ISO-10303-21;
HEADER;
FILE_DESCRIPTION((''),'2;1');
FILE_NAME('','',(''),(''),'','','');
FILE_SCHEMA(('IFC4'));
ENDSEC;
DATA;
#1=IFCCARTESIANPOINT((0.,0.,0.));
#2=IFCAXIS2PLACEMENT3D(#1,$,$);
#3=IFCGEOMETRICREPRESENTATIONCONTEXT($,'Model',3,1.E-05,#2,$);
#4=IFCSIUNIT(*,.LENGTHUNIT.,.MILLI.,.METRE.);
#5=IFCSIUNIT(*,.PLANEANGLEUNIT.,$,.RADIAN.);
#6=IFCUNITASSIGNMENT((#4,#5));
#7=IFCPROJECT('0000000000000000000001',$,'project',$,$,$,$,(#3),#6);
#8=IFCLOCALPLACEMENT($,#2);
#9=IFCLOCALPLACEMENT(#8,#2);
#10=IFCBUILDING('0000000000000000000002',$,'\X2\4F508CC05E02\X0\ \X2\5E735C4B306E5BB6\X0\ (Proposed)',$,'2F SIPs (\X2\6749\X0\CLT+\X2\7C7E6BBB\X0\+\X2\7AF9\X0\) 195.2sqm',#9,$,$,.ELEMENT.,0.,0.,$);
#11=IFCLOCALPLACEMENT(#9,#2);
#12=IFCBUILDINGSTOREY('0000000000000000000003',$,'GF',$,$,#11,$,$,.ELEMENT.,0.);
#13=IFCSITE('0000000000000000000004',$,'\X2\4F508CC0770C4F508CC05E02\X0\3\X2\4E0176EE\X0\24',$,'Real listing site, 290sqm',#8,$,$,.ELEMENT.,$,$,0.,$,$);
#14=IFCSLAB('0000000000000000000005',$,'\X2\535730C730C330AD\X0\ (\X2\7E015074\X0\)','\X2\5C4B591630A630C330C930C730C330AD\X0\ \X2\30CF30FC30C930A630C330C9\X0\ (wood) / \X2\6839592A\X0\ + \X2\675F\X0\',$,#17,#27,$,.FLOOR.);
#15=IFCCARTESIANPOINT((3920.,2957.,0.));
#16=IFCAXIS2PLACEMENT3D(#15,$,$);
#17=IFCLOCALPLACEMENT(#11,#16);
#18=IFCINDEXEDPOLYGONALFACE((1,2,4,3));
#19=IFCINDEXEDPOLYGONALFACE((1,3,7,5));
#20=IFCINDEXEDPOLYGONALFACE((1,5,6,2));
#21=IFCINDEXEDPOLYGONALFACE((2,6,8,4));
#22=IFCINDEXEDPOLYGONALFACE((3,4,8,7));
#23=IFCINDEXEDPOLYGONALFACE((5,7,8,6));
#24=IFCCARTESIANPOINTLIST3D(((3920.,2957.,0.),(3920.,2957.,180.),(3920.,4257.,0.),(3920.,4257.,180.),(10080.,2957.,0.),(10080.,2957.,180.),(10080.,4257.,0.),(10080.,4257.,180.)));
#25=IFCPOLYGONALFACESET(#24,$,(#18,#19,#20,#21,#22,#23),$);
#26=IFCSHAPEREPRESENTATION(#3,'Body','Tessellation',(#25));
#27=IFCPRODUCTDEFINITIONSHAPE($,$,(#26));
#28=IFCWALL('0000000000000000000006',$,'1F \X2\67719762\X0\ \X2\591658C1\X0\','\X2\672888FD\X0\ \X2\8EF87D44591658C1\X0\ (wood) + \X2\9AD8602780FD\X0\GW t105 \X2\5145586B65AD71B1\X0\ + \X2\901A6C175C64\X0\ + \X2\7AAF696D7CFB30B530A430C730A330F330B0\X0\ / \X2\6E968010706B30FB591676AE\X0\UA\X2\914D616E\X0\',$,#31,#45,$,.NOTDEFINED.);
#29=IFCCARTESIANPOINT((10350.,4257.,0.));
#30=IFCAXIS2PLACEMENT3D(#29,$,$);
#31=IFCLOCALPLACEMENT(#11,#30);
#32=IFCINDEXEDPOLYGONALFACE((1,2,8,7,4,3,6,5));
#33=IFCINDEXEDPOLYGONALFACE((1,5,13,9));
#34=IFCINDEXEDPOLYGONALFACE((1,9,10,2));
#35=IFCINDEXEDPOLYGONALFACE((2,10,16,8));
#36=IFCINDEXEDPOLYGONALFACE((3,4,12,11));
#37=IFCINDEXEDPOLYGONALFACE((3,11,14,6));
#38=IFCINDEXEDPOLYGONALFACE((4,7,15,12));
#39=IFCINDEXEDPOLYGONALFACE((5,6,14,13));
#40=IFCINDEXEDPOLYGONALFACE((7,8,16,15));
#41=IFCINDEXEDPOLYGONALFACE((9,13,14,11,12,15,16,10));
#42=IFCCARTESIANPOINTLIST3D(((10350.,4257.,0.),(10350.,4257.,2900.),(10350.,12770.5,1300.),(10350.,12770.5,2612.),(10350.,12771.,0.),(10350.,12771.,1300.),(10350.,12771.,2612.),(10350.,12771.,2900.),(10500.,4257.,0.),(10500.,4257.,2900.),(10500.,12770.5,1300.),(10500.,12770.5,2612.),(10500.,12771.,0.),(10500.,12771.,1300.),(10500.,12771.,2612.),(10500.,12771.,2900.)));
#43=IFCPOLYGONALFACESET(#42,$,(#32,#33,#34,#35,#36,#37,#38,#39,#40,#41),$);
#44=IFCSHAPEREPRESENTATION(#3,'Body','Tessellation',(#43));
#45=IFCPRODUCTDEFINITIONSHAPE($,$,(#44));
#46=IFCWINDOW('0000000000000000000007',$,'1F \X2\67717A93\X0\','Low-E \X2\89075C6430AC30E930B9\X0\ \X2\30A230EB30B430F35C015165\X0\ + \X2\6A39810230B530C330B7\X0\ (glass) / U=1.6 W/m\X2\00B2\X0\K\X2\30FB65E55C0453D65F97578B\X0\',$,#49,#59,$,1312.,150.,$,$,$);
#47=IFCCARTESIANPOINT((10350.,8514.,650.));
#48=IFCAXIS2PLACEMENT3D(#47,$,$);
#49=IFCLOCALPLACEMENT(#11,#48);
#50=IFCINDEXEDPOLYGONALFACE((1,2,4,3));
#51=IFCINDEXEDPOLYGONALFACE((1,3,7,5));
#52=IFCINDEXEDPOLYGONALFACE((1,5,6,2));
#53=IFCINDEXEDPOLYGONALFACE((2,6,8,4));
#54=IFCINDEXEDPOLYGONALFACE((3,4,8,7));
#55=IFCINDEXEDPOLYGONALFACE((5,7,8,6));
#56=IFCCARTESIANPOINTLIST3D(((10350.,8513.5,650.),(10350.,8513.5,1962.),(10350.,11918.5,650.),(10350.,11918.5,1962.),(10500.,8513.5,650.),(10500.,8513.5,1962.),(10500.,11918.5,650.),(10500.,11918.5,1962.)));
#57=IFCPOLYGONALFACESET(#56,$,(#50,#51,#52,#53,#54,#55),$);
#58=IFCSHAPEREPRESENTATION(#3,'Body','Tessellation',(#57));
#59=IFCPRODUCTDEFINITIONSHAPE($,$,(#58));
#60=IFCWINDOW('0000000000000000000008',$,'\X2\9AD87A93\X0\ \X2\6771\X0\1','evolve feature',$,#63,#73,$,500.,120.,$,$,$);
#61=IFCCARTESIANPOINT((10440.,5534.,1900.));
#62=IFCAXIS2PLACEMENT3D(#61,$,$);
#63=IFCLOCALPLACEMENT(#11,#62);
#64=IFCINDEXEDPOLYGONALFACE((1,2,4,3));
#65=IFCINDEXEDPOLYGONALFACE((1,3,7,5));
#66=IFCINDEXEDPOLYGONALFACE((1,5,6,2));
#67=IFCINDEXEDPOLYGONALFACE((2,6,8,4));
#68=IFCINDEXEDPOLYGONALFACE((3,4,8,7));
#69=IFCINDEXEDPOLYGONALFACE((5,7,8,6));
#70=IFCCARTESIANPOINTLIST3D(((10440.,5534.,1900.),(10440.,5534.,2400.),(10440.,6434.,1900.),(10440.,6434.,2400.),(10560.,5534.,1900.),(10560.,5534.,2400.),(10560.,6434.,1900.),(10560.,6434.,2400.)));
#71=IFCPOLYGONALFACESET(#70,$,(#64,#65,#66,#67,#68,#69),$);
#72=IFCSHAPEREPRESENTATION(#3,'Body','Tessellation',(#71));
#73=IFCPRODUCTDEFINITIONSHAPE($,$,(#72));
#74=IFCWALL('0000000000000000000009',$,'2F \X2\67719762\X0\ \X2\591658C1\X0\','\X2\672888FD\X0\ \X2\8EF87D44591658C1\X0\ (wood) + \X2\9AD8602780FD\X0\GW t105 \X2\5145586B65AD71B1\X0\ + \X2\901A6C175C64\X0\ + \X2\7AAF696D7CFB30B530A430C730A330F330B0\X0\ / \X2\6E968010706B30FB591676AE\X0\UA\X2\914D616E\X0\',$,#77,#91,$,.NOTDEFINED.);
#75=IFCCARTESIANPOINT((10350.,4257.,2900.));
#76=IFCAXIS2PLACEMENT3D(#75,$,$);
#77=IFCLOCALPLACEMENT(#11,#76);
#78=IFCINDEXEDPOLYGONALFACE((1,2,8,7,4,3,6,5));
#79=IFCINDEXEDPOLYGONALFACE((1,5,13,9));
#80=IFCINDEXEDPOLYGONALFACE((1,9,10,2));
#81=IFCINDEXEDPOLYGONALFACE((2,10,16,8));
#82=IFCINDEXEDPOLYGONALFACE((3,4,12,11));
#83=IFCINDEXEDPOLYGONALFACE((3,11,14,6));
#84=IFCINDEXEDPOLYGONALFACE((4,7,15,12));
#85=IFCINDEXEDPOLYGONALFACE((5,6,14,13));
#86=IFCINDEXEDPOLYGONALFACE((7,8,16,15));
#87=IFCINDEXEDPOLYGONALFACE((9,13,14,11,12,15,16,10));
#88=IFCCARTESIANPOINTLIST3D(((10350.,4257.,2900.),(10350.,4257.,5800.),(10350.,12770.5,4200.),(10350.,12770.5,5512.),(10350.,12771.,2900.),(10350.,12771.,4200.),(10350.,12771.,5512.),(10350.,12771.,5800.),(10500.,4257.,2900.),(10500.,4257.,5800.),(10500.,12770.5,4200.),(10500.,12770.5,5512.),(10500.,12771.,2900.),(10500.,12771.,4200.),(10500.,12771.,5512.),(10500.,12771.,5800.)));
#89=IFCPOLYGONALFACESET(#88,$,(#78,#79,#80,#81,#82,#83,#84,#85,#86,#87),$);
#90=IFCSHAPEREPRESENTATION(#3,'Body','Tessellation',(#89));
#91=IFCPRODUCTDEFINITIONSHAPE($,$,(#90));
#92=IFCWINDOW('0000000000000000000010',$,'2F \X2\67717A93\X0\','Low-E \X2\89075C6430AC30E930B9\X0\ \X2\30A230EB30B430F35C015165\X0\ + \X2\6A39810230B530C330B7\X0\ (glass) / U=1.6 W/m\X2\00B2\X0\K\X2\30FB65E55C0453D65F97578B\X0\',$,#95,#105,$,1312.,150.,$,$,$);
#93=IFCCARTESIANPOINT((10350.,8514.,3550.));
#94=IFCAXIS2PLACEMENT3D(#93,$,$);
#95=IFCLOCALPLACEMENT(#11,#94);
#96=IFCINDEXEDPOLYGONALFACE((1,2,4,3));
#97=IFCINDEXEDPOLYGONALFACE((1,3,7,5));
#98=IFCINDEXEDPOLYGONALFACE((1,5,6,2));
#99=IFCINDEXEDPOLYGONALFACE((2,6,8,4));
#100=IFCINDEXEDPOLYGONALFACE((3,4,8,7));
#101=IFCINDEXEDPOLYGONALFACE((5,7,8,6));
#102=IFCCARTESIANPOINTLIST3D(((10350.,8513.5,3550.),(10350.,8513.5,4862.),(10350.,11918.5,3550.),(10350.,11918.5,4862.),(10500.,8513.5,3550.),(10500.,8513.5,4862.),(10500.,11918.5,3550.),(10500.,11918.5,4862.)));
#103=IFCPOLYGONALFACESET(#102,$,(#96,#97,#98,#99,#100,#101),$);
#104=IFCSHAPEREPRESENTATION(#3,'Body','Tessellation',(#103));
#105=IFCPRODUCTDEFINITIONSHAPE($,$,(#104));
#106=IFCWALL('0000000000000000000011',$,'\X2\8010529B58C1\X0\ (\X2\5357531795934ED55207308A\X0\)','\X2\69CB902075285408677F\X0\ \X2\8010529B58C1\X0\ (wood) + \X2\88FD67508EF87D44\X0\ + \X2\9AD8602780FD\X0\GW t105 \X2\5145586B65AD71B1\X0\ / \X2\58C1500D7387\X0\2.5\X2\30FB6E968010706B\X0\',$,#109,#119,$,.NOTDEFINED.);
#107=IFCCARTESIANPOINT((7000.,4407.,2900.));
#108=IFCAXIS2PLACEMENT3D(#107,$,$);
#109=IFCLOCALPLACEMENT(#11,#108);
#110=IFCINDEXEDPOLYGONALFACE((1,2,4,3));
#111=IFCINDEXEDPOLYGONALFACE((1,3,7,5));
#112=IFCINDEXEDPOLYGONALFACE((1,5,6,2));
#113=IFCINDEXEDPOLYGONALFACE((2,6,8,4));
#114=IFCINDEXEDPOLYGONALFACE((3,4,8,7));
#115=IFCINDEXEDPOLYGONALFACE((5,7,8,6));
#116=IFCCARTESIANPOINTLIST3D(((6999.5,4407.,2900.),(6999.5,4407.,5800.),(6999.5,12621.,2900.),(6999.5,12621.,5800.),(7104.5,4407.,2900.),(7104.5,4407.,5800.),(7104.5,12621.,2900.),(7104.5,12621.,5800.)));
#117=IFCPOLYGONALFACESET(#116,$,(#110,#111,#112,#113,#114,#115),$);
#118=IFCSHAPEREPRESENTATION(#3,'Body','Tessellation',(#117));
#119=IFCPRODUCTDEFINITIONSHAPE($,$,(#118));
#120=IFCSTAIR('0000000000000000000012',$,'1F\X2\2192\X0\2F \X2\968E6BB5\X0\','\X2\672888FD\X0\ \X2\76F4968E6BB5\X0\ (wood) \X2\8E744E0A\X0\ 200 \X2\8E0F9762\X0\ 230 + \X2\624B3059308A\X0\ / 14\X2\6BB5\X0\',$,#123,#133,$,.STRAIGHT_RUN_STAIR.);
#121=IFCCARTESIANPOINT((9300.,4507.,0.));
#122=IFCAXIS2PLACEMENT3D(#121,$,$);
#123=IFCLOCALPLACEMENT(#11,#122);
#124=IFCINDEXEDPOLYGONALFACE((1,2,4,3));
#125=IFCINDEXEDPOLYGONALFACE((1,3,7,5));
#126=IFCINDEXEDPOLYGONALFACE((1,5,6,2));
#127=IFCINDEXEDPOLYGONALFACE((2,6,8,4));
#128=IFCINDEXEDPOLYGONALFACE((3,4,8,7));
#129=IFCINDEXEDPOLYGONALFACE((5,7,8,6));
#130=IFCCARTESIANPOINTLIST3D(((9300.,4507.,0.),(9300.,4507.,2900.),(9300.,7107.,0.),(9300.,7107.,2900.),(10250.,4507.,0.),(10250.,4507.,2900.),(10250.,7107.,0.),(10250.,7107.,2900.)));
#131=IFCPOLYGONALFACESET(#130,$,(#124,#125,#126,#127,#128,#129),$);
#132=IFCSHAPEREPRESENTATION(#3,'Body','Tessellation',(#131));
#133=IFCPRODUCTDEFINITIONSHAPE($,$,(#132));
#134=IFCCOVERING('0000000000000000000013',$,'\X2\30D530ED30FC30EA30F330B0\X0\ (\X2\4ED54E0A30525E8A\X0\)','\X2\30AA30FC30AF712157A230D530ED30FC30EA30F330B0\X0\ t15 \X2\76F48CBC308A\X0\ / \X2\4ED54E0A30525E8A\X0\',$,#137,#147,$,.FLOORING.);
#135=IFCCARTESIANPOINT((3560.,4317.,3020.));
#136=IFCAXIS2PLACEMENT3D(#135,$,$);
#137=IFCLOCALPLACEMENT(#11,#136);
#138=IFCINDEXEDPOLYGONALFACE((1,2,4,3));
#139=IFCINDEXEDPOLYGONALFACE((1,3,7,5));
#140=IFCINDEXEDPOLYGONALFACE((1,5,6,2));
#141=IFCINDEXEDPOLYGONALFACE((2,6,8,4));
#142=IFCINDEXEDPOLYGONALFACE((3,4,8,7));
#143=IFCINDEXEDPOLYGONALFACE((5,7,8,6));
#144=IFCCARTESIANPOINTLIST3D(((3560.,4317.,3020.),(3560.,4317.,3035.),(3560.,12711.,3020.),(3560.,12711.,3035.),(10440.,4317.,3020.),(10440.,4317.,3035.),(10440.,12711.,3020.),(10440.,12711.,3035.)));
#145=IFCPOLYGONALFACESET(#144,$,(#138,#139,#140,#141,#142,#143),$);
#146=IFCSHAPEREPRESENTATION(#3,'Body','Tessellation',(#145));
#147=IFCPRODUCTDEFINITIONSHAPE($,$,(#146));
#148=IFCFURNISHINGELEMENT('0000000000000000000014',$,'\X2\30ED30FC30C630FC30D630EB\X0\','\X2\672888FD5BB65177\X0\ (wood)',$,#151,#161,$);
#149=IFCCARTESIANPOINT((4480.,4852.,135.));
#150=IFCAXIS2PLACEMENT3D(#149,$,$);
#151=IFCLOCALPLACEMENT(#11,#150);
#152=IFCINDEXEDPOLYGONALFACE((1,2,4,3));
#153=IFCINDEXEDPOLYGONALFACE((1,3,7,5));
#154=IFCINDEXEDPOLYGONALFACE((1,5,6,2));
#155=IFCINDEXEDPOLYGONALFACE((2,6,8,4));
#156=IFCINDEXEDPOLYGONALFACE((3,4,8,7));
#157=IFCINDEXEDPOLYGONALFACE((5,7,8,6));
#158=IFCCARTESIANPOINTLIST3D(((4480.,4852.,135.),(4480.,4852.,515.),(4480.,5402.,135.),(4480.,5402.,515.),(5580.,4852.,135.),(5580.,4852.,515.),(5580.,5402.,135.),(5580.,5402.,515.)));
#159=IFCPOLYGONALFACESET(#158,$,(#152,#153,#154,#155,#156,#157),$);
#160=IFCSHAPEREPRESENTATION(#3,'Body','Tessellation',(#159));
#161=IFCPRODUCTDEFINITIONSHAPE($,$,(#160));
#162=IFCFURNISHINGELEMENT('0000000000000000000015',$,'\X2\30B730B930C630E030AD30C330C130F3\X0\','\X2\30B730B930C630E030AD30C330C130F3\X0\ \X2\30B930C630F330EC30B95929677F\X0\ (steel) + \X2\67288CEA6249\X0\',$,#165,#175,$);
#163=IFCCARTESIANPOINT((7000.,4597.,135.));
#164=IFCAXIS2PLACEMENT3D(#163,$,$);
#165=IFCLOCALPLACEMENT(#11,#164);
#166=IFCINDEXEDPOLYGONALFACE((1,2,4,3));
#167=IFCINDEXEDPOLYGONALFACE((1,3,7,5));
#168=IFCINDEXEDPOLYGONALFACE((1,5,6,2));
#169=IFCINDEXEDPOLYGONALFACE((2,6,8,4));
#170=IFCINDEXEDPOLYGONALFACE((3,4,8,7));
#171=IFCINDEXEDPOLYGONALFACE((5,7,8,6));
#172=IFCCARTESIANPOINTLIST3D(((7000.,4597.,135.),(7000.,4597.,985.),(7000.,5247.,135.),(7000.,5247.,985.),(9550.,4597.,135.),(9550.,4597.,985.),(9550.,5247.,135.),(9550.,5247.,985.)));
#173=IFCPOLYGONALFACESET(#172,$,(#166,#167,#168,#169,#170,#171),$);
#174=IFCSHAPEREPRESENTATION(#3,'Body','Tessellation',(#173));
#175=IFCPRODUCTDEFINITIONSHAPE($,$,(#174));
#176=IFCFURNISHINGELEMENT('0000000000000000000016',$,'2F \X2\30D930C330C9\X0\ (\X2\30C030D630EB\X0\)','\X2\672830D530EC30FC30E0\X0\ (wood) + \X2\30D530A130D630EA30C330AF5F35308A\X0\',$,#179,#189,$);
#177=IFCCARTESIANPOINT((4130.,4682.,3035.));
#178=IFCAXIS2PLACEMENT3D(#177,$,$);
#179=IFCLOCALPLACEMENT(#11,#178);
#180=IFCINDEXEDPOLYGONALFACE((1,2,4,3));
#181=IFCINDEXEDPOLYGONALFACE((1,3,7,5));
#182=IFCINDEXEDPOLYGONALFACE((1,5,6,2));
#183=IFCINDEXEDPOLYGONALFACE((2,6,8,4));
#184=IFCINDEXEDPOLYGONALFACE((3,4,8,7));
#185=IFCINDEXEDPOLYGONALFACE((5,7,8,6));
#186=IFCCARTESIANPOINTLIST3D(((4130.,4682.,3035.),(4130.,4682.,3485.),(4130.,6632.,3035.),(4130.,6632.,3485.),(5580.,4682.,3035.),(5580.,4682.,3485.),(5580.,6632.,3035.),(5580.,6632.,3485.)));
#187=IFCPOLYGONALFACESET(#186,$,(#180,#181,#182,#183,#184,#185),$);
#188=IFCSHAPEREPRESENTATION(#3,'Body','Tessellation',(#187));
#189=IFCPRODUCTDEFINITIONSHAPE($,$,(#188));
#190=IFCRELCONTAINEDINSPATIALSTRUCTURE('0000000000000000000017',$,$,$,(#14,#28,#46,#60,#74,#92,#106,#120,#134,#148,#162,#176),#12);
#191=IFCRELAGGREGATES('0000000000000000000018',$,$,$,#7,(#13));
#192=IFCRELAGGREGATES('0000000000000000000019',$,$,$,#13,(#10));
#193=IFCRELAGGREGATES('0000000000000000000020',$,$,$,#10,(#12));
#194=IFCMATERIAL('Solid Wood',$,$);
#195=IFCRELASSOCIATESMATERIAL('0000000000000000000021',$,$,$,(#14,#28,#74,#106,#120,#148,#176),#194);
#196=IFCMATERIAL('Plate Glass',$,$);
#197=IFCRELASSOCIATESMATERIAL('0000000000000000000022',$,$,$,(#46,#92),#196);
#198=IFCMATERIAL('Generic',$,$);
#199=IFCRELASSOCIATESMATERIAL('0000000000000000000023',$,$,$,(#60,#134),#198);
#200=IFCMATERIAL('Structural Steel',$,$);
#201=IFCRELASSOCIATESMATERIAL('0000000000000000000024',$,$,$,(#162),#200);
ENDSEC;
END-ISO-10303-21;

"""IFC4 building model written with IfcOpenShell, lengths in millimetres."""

from ifc_helpers import new_model, si_unit, frame, frame_2d, origin, place, context, project, spatial, rectangle, extrude, material, element, fill, save


model = new_model("IFC4")

# Units and contexts
model_context = context("Model", 3, precision=1e-05, world=origin())
ifc_project = project(units=[si_unit("LENGTHUNIT", "METRE", prefix="MILLI"), si_unit("PLANEANGLEUNIT", "RADIAN")], contexts=[model_context])

# Site, building, storey
site_placement = place(None, origin())
site = spatial("IfcSite", under=ifc_project, at=site_placement, Name="佐賀県佐賀市3丁目24", ObjectType="Real listing site, 290sqm", CompositionType="ELEMENT", RefElevation=0.0)
building_placement = place(site_placement, origin())
building = spatial("IfcBuilding", under=site, at=building_placement, Name="佐賀市 平屋の家 (Proposed)", ObjectType="2F SIPs (杉CLT+籾殻+竹) 195.2sqm", CompositionType="ELEMENT", ElevationOfRefHeight=0.0, ElevationOfTerrain=0.0)
storey_placement = place(building_placement, origin())
storey = spatial("IfcBuildingStorey", under=building, at=storey_placement, Name="GF", CompositionType="ELEMENT", Elevation=0.0)

# Slab
ifc_material_1 = material(Name="Solid Wood")
slab_placement = place(storey_placement, frame((3920.0, 2957.0, 0.0)))
element("IfcSlab", 1, at=slab_placement, inside=storey, material=ifc_material_1, Name="南デッキ (縁側)", Description="屋外ウッドデッキ ハードウッド (wood) / 根太 + 束", PredefinedType="FLOOR", context=model_context, shape_type="SweptSolid", body=[
    extrude(rectangle(XDim=6160.0, YDim=1300.0, at=frame_2d((3080.0, 650.0))), frame((3920.0, 2957.0, 0.0)), (0.0, 0.0, 1.0), 180.0),
])

# Wall, openings, windows
wall_1_placement = place(storey_placement, frame((10350.0, 4257.0, 0.0)))
wall_1 = element("IfcWall", 2, at=wall_1_placement, inside=storey, material=ifc_material_1, Name="1F 東面 外壁", Description="木製 軸組外壁 (wood) + 高性能GW t105 充填断熱 + 通気層 + 窯業系サイディング / 準耐火・外皮UA配慮", PredefinedType="NOTDEFINED", context=model_context, shape_type="SweptSolid", body=[
    extrude(rectangle(XDim=150.0, YDim=8514.0, at=frame_2d((75.0, 4257.0))), frame((10350.0, 4257.0, 0.0)), (0.0, 0.0, 1.0), 2900.0),
])
opening_1_placement = place(storey_placement, frame((10350.0, 8514.0, 650.0)))
opening_1 = element("IfcOpeningElement", 3, at=opening_1_placement, cuts=wall_1, PredefinedType="NOTDEFINED", context=model_context, shape_type="SweptSolid", body=[
    extrude(rectangle(XDim=150.0, YDim=3405.0, at=frame_2d((75.0, 1702.0))), frame((10350.0, 8514.0, 650.0)), (0.0, 0.0, 1.0), 1312.0),
])
opening_2_placement = place(storey_placement, frame((10440.0, 5534.0, 1900.0)))
opening_2 = element("IfcOpeningElement", 4, at=opening_2_placement, cuts=wall_1, PredefinedType="NOTDEFINED", context=model_context, shape_type="SweptSolid", body=[
    extrude(rectangle(XDim=120.0, YDim=900.0, at=frame_2d((60.0, 450.0))), frame((10440.0, 5534.0, 1900.0)), (0.0, 0.0, 1.0), 500.0),
])
ifc_material_2 = material(Name="Plate Glass")
window_1_placement = place(storey_placement, frame((10350.0, 8514.0, 650.0)))
window_1 = element("IfcWindow", 5, at=window_1_placement, inside=storey, material=ifc_material_2, Name="1F 東窓", Description="Low-E 複層ガラス アルゴン封入 + 樹脂サッシ (glass) / U=1.6 W/m²K・日射取得型", OverallHeight=1312.0, OverallWidth=150.0, context=model_context, shape_type="SweptSolid", body=[
    extrude(rectangle(XDim=150.0, YDim=3405.0, at=frame_2d((75.0, 1702.0))), frame((10350.0, 8514.0, 650.0)), (0.0, 0.0, 1.0), 1312.0),
])
fill(opening_1, window_1)
ifc_material_3 = material(Name="Generic")
window_2_placement = place(storey_placement, frame((10440.0, 5534.0, 1900.0)))
window_2 = element("IfcWindow", 6, at=window_2_placement, inside=storey, material=ifc_material_3, Name="高窓 東1", Description="evolve feature", OverallHeight=500.0, OverallWidth=120.0, context=model_context, shape_type="SweptSolid", body=[
    extrude(rectangle(XDim=120.0, YDim=900.0, at=frame_2d((60.0, 450.0))), frame((10440.0, 5534.0, 1900.0)), (0.0, 0.0, 1.0), 500.0),
])
fill(opening_2, window_2)

# Wall, opening, window
wall_2_placement = place(storey_placement, frame((10350.0, 4257.0, 2900.0)))
wall_2 = element("IfcWall", 7, at=wall_2_placement, inside=storey, material=ifc_material_1, Name="2F 東面 外壁", Description="木製 軸組外壁 (wood) + 高性能GW t105 充填断熱 + 通気層 + 窯業系サイディング / 準耐火・外皮UA配慮", PredefinedType="NOTDEFINED", context=model_context, shape_type="SweptSolid", body=[
    extrude(rectangle(XDim=150.0, YDim=8514.0, at=frame_2d((75.0, 4257.0))), frame((10350.0, 4257.0, 2900.0)), (0.0, 0.0, 1.0), 2900.0),
])
opening_3_placement = place(storey_placement, frame((10350.0, 8514.0, 3550.0)))
opening_3 = element("IfcOpeningElement", 8, at=opening_3_placement, cuts=wall_2, PredefinedType="NOTDEFINED", context=model_context, shape_type="SweptSolid", body=[
    extrude(rectangle(XDim=150.0, YDim=3405.0, at=frame_2d((75.0, 1702.0))), frame((10350.0, 8514.0, 3550.0)), (0.0, 0.0, 1.0), 1312.0),
])
window_3_placement = place(storey_placement, frame((10350.0, 8514.0, 3550.0)))
window_3 = element("IfcWindow", 9, at=window_3_placement, inside=storey, material=ifc_material_2, Name="2F 東窓", Description="Low-E 複層ガラス アルゴン封入 + 樹脂サッシ (glass) / U=1.6 W/m²K・日射取得型", OverallHeight=1312.0, OverallWidth=150.0, context=model_context, shape_type="SweptSolid", body=[
    extrude(rectangle(XDim=150.0, YDim=3405.0, at=frame_2d((75.0, 1702.0))), frame((10350.0, 8514.0, 3550.0)), (0.0, 0.0, 1.0), 1312.0),
])
fill(opening_3, window_3)

# Wall
wall_3_placement = place(storey_placement, frame((7000.0, 4407.0, 2900.0)))
element("IfcWall", 10, at=wall_3_placement, inside=storey, material=ifc_material_1, Name="耐力壁 (南北間仕切り)", Description="構造用合板 耐力壁 (wood) + 製材軸組 + 高性能GW t105 充填断熱 / 壁倍率2.5・準耐火", PredefinedType="NOTDEFINED", context=model_context, shape_type="SweptSolid", body=[
    extrude(rectangle(XDim=105.0, YDim=8214.0, at=frame_2d((52.0, 4107.0))), frame((7000.0, 4407.0, 2900.0)), (0.0, 0.0, 1.0), 2900.0),
])

# Stair
stair_placement = place(storey_placement, frame((9300.0, 4507.0, 0.0)))
element("IfcStair", 11, at=stair_placement, inside=storey, material=ifc_material_1, Name="1F→2F 階段", Description="木製 直階段 (wood) 蹴上 200 踏面 230 + 手すり / 14段", PredefinedType="STRAIGHT_RUN_STAIR", context=model_context, shape_type="SweptSolid", body=[
    extrude(rectangle(XDim=950.0, YDim=2600.0, at=frame_2d((475.0, 1300.0))), frame((9300.0, 4507.0, 0.0)), (0.0, 0.0, 1.0), 2900.0),
])

# Covering
covering_placement = place(storey_placement, frame((3560.0, 4317.0, 3020.0)))
element("IfcCovering", 12, at=covering_placement, inside=storey, material=ifc_material_3, Name="フローリング (仕上げ床)", Description="オーク無垢フローリング t15 直貼り / 仕上げ床", PredefinedType="FLOORING", context=model_context, shape_type="SweptSolid", body=[
    extrude(rectangle(XDim=6880.0, YDim=8394.0, at=frame_2d((3440.0, 4197.0))), frame((3560.0, 4317.0, 3020.0)), (0.0, 0.0, 1.0), 15.0),
])

# Furnishing elements
furnishing_1_placement = place(storey_placement, frame((4480.0, 4852.0, 135.0)))
element("IfcFurnishingElement", 13, at=furnishing_1_placement, inside=storey, material=ifc_material_1, Name="ローテーブル", Description="木製家具 (wood)", context=model_context, shape_type="SweptSolid", body=[
    extrude(rectangle(XDim=1100.0, YDim=550.0, at=frame_2d((550.0, 275.0))), frame((4480.0, 4852.0, 135.0)), (0.0, 0.0, 1.0), 380.0),
])
ifc_material_4 = material(Name="Structural Steel")
furnishing_2_placement = place(storey_placement, frame((7000.0, 4597.0, 135.0)))
element("IfcFurnishingElement", 14, at=furnishing_2_placement, inside=storey, material=ifc_material_4, Name="システムキッチン", Description="システムキッチン ステンレス天板 (steel) + 木質扉", context=model_context, shape_type="SweptSolid", body=[
    extrude(rectangle(XDim=2550.0, YDim=650.0, at=frame_2d((1275.0, 325.0))), frame((7000.0, 4597.0, 135.0)), (0.0, 0.0, 1.0), 850.0),
])
furnishing_3_placement = place(storey_placement, frame((4130.0, 4682.0, 3035.0)))
element("IfcFurnishingElement", 15, at=furnishing_3_placement, inside=storey, material=ifc_material_1, Name="2F ベッド (ダブル)", Description="木フレーム (wood) + ファブリック張り", context=model_context, shape_type="SweptSolid", body=[
    extrude(rectangle(XDim=1450.0, YDim=1950.0, at=frame_2d((725.0, 975.0))), frame((4130.0, 4682.0, 3035.0)), (0.0, 0.0, 1.0), 450.0),
])

save(model, "model.ifc")
